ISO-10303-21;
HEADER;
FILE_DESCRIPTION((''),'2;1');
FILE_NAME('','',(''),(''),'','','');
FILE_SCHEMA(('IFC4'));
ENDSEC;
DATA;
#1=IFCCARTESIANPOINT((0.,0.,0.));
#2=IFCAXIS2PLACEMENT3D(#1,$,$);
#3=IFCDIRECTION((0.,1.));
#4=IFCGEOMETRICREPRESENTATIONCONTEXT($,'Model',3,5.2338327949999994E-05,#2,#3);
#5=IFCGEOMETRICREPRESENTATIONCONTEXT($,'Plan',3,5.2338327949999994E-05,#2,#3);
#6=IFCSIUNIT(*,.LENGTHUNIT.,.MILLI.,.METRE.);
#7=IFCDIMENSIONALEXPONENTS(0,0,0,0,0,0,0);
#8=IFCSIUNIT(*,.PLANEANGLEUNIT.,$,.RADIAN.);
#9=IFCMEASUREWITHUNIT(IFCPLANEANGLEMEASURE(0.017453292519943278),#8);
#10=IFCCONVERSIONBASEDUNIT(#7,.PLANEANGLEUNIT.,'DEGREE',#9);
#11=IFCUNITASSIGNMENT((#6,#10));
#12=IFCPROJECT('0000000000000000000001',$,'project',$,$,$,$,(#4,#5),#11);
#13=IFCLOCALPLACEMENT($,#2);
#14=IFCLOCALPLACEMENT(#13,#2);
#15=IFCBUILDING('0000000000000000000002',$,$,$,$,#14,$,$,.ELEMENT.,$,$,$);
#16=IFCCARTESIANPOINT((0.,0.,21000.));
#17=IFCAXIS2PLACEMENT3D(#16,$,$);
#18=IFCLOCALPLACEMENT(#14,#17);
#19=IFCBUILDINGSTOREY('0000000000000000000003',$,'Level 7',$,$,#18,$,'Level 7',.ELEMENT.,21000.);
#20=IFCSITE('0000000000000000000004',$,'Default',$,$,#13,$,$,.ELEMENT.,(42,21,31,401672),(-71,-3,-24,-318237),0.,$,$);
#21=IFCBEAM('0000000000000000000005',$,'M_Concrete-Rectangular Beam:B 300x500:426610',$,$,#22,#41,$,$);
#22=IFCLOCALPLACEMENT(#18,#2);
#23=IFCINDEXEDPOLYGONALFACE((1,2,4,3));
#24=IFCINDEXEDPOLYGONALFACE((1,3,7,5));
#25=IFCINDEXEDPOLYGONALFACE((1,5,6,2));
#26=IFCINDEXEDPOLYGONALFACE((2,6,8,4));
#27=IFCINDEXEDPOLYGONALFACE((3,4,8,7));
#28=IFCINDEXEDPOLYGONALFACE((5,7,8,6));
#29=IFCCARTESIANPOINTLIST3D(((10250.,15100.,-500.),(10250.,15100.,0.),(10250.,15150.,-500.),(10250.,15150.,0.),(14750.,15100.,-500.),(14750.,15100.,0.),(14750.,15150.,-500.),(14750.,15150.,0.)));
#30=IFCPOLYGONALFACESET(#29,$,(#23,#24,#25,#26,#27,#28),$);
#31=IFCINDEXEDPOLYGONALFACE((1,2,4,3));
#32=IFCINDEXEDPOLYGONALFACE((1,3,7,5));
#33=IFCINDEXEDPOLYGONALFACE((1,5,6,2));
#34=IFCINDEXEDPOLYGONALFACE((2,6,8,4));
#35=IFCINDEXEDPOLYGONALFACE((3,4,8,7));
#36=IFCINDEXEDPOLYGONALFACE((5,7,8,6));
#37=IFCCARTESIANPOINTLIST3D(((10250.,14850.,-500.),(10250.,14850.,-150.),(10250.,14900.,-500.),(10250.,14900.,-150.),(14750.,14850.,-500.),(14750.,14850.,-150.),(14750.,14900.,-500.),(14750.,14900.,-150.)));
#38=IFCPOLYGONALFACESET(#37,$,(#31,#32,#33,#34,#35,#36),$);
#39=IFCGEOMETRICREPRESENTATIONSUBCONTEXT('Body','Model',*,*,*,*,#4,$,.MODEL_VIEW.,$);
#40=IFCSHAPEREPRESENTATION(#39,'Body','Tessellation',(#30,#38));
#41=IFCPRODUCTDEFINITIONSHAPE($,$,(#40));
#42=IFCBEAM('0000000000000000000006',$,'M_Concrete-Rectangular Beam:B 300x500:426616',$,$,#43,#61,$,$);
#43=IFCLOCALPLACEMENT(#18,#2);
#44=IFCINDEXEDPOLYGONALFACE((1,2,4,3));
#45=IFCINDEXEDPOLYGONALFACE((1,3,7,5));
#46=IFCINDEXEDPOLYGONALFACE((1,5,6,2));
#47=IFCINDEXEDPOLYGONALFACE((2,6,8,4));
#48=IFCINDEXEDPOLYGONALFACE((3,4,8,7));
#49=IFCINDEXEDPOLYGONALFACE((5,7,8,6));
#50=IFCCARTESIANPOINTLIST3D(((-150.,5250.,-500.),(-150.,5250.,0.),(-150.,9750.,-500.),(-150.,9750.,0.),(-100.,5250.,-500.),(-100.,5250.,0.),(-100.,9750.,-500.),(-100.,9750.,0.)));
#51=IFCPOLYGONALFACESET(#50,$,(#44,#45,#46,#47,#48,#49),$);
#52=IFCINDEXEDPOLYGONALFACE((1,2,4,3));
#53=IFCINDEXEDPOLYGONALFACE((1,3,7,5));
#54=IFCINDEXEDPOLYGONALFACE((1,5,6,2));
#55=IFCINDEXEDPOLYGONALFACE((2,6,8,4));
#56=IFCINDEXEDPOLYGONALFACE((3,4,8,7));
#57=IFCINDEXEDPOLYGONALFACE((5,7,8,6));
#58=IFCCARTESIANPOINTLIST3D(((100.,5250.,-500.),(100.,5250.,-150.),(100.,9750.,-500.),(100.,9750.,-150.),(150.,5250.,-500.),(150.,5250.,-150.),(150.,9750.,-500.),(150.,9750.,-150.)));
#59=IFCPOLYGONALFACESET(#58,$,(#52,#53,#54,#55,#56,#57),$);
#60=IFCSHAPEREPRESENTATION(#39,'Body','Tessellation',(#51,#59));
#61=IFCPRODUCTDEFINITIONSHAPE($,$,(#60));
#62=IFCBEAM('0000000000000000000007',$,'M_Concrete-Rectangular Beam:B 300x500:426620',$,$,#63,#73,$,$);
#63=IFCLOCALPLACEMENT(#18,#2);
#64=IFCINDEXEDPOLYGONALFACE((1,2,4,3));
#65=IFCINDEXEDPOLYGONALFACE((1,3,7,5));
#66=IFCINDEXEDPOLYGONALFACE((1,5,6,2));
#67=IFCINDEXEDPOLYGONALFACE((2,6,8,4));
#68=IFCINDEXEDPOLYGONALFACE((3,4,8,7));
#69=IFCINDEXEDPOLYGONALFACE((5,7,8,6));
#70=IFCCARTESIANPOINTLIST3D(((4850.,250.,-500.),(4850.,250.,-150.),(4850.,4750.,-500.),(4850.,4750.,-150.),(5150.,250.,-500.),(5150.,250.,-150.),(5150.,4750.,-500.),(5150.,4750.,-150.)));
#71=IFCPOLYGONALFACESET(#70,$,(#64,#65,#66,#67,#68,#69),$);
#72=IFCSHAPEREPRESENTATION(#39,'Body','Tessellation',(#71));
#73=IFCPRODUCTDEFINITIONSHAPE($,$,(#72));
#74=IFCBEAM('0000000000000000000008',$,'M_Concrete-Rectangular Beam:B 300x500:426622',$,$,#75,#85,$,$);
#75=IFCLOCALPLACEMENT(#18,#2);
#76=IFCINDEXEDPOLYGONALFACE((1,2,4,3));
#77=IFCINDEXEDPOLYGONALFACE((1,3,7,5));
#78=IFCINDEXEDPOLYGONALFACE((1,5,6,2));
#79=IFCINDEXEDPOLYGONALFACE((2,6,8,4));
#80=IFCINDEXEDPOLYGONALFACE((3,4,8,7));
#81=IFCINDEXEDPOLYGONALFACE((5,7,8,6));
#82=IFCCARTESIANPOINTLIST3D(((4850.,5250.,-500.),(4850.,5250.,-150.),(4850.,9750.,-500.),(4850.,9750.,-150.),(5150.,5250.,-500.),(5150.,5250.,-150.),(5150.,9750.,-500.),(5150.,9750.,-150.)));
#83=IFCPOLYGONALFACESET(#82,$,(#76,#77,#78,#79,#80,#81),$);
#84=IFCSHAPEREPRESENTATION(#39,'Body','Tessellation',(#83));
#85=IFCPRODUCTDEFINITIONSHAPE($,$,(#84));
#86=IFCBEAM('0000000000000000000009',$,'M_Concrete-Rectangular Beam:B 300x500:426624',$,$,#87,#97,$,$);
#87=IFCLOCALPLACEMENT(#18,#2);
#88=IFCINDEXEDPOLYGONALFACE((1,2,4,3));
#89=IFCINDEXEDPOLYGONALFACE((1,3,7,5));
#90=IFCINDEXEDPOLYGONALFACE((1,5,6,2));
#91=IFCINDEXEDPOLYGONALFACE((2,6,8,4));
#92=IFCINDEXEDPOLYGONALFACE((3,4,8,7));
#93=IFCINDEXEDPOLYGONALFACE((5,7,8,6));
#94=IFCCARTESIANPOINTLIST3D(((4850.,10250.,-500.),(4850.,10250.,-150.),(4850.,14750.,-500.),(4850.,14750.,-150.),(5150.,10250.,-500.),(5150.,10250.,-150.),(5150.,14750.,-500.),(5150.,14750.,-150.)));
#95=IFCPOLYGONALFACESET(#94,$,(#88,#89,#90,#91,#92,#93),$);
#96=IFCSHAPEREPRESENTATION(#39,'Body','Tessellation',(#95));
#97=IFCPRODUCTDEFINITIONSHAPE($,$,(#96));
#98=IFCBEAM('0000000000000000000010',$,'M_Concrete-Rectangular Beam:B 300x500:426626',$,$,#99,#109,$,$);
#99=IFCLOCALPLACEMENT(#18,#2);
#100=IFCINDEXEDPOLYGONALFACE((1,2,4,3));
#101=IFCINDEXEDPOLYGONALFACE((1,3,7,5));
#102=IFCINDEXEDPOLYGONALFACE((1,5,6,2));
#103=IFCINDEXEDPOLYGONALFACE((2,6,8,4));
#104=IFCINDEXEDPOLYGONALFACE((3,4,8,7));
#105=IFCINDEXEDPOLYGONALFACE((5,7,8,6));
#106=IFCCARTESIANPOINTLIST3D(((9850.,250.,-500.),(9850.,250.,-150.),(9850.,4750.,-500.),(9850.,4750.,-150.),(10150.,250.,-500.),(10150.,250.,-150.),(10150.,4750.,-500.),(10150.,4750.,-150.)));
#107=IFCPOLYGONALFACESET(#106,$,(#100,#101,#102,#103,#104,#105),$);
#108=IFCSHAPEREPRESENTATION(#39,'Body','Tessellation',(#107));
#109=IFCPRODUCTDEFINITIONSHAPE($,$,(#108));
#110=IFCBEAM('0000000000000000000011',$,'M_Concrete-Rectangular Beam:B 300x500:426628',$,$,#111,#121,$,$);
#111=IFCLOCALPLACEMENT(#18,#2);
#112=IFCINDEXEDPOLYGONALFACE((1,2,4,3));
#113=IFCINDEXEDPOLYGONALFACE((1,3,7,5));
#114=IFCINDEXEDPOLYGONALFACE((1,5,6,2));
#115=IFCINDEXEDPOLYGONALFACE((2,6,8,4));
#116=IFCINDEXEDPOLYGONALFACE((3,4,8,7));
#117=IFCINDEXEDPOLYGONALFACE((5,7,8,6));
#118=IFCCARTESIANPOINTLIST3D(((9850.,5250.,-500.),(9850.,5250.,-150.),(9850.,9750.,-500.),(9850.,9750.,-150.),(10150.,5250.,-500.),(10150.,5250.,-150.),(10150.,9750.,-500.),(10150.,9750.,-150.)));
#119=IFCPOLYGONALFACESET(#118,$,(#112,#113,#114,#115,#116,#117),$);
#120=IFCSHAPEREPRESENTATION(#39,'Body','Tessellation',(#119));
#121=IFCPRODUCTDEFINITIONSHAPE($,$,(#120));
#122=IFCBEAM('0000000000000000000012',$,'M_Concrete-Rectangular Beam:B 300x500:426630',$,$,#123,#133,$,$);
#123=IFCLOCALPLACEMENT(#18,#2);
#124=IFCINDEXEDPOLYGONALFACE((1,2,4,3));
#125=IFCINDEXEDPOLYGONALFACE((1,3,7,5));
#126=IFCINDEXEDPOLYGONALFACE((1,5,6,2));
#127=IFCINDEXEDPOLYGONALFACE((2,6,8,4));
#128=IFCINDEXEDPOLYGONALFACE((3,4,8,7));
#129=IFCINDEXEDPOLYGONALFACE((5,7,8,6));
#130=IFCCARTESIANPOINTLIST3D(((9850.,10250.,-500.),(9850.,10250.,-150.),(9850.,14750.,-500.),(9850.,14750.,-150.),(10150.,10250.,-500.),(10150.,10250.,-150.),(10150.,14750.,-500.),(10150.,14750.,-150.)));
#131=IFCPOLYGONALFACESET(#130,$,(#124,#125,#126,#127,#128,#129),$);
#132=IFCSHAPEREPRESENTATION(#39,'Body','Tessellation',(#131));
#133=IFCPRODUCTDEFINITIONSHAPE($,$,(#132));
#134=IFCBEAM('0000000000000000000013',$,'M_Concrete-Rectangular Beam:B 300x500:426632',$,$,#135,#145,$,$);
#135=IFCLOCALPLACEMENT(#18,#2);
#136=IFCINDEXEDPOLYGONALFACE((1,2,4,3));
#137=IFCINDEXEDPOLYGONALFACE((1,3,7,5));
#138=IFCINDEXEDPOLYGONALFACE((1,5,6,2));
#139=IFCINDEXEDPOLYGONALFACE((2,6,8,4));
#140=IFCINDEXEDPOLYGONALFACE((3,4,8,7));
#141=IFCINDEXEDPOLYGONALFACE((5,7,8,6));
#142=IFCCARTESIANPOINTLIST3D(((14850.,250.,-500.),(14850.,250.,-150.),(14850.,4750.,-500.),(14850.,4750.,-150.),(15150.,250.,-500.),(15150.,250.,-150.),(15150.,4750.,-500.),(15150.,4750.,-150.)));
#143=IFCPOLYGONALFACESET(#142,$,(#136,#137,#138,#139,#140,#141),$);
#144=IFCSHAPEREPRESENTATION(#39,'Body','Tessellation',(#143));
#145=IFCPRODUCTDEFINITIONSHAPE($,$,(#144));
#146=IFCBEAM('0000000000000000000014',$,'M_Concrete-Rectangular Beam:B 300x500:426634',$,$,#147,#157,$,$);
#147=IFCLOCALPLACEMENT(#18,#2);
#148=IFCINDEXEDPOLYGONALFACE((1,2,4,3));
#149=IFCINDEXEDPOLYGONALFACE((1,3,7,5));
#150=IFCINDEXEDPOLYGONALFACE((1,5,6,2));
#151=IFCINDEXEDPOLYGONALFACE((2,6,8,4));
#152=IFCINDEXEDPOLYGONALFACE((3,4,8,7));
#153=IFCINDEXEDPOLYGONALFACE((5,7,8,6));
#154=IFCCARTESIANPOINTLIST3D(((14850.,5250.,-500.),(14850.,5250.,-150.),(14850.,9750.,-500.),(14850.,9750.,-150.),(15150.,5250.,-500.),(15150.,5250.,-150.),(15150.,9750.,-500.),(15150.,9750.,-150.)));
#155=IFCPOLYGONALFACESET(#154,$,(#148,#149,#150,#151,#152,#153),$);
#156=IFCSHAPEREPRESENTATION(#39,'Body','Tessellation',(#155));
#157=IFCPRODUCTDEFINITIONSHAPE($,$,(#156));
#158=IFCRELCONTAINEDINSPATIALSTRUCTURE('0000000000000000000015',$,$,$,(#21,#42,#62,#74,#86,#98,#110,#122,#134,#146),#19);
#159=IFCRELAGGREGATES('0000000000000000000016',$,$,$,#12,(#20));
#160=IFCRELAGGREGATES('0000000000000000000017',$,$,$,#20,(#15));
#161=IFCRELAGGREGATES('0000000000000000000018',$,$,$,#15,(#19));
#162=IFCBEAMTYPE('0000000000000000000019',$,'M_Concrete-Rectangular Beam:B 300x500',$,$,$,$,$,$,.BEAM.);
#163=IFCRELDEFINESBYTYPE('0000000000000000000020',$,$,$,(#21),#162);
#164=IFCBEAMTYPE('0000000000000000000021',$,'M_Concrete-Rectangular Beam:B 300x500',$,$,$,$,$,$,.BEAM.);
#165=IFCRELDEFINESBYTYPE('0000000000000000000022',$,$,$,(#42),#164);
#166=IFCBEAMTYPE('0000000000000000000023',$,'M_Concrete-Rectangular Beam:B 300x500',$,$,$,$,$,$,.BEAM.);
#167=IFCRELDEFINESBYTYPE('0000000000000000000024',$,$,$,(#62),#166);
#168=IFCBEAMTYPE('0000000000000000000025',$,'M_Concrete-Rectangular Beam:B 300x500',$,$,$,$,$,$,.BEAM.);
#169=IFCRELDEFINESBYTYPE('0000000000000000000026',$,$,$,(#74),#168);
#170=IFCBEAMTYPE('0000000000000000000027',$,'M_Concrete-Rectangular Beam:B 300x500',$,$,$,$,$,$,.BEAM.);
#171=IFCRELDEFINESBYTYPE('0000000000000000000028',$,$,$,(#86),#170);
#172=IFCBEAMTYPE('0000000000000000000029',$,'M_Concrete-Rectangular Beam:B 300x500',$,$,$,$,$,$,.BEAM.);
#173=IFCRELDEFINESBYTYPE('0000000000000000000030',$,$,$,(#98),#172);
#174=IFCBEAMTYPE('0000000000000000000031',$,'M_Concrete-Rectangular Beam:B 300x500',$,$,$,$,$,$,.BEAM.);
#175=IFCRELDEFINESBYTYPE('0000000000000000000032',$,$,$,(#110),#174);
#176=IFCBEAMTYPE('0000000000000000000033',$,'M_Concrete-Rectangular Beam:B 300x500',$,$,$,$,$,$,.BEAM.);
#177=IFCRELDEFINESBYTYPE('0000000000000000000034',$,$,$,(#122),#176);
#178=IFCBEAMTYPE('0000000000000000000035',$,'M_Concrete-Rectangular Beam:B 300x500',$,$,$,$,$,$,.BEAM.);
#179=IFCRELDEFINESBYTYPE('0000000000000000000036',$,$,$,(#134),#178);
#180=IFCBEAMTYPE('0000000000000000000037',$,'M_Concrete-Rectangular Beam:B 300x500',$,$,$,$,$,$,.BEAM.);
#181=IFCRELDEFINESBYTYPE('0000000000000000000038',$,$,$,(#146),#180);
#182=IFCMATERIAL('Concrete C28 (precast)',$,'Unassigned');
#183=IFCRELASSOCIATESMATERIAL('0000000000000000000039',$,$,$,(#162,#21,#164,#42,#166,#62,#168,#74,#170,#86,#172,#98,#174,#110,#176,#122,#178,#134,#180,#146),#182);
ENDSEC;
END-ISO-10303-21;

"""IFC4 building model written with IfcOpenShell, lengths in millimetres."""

from ifc_helpers import new_model, entity, si_unit, converted_unit, direction, frame, origin, place, context, subcontext, project, spatial, indexed_curve, outline, extrude, source, transform, mapped, material, type_object, type_shapes, element, save


model = new_model("IFC4")

# Units and contexts
model_context = context("Model", 3, precision=5.2338327949999994e-05, world=origin(), true_north=direction((0.0, 1.0)))
plan_context = context("Plan", 3, precision=5.2338327949999994e-05, world=origin(), true_north=direction((0.0, 1.0)))
body_context = subcontext(model_context, "Body", "Model", "MODEL_VIEW")
ifc_project = project(units=[si_unit("LENGTHUNIT", "METRE", prefix="MILLI"), converted_unit("PLANEANGLEUNIT", "DEGREE", entity("IfcPlaneAngleMeasure", 0.017453292519943278), si_unit("PLANEANGLEUNIT", "RADIAN"), dimensions=[0, 0, 0, 0, 0, 0, 0])], contexts=[model_context, plan_context])

# Site, building, storey
site_placement = place(None, origin())
site = spatial("IfcSite", under=ifc_project, at=site_placement, Name="Default", CompositionType="ELEMENT", RefLatitude=(42, 21, 31, 401672), RefLongitude=(-71, -3, -24, -318237), RefElevation=0.0)
building_placement = place(site_placement, origin())
building = spatial("IfcBuilding", under=site, at=building_placement, CompositionType="ELEMENT")
storey_placement = place(building_placement, frame((0.0, 0.0, 21000.0)))
storey = spatial("IfcBuildingStorey", under=building, at=storey_placement, Name="Level 7", LongName="Level 7", CompositionType="ELEMENT", Elevation=21000.0)

# Beams
ifc_material = material(Name="Concrete C28 (precast)", Category="Unassigned")
beam_type_1 = type_object("IfcBeamType", Name="M_Concrete-Rectangular Beam:B 300x500", PredefinedType="BEAM", material=ifc_material)
shared_shape_1 = source(origin(), body_context, "Body", "SweptSolid", [
    extrude(outline(indexed_curve([(-250.0, -25.0), (250.0, -25.0), (250.0, 25.0), (-250.0, 25.0), (-250.0, -25.0)], self_intersect=False)), frame((10250.0, 15125.0, 20750.0), z_axis=(1.0, 0.0, 0.0), x_axis=(0.0, 0.0, -1.0)), (0.0, 0.0, 1.0), 4500.0),
    extrude(outline(indexed_curve([(-175.0, -25.0), (175.0, -25.0), (175.0, 25.0), (-175.0, 25.0), (-175.0, -25.0)], self_intersect=False)), frame((10250.0, 14875.0, 20675.0), z_axis=(1.0, 0.0, 0.0), x_axis=(0.0, 0.0, -1.0)), (0.0, 0.0, 1.0), 4500.0),
])
type_shapes(beam_type_1, [shared_shape_1])
beam_1_placement = place(storey_placement, frame((0.0, 0.0, -21000.0)))
element("IfcBeam", 1, at=beam_1_placement, inside=storey, type_object=beam_type_1, material=ifc_material, Name="M_Concrete-Rectangular Beam:B 300x500:426610", context=body_context, shape_type="MappedRepresentation", body=[
    mapped(shared_shape_1, transform((0.0, 0.0, 0.0), scale=1.0)),
])
beam_type_2 = type_object("IfcBeamType", Name="M_Concrete-Rectangular Beam:B 300x500", PredefinedType="BEAM", material=ifc_material)
shared_shape_2 = source(origin(), body_context, "Body", "SweptSolid", [
    extrude(outline(indexed_curve([(-25.0, -250.0), (25.0, -250.0), (25.0, 250.0), (-25.0, 250.0), (-25.0, -250.0)], self_intersect=False)), frame((-125.0, 5250.0, 20750.0), z_axis=(0.0, 1.0, 0.0), x_axis=(-1.0, 0.0, 0.0)), (0.0, 0.0, 1.0), 4500.0),
    extrude(outline(indexed_curve([(-25.0, -175.0), (25.0, -175.0), (25.0, 175.0), (-25.0, 175.0), (-25.0, -175.0)], self_intersect=False)), frame((125.0, 5250.0, 20675.0), z_axis=(0.0, 1.0, 0.0), x_axis=(-1.0, 0.0, 0.0)), (0.0, 0.0, 1.0), 4500.0),
])
type_shapes(beam_type_2, [shared_shape_2])
beam_2_placement = place(storey_placement, frame((0.0, 0.0, -21000.0)))
element("IfcBeam", 2, at=beam_2_placement, inside=storey, type_object=beam_type_2, material=ifc_material, Name="M_Concrete-Rectangular Beam:B 300x500:426616", context=body_context, shape_type="MappedRepresentation", body=[
    mapped(shared_shape_2, transform((0.0, 0.0, 0.0), scale=1.0)),
])
beam_type_3 = type_object("IfcBeamType", Name="M_Concrete-Rectangular Beam:B 300x500", PredefinedType="BEAM", material=ifc_material)
shared_shape_3 = source(origin(), body_context, "Body", "SweptSolid", [
    extrude(outline(indexed_curve([(-150.0, -175.0), (150.0, -175.0), (150.0, 175.0), (-150.0, 175.0), (-150.0, -175.0)], self_intersect=False)), frame((5000.0, 250.0, 20675.0), z_axis=(0.0, 1.0, 0.0), x_axis=(-1.0, 0.0, 0.0)), (0.0, 0.0, 1.0), 4500.0),
])
type_shapes(beam_type_3, [shared_shape_3])
beam_3_placement = place(storey_placement, frame((0.0, 0.0, -21000.0)))
element("IfcBeam", 3, at=beam_3_placement, inside=storey, type_object=beam_type_3, material=ifc_material, Name="M_Concrete-Rectangular Beam:B 300x500:426620", context=body_context, shape_type="MappedRepresentation", body=[
    mapped(shared_shape_3, transform((0.0, 0.0, 0.0), scale=1.0)),
])
beam_type_4 = type_object("IfcBeamType", Name="M_Concrete-Rectangular Beam:B 300x500", PredefinedType="BEAM", material=ifc_material)
shared_shape_4 = source(origin(), body_context, "Body", "SweptSolid", [
    extrude(outline(indexed_curve([(-150.0, -175.0), (150.0, -175.0), (150.0, 175.0), (-150.0, 175.0), (-150.0, -175.0)], self_intersect=False)), frame((5000.0, 5250.0, 20675.0), z_axis=(0.0, 1.0, 0.0), x_axis=(-1.0, 0.0, 0.0)), (0.0, 0.0, 1.0), 4500.0),
])
type_shapes(beam_type_4, [shared_shape_4])
beam_4_placement = place(storey_placement, frame((0.0, 0.0, -21000.0)))
element("IfcBeam", 4, at=beam_4_placement, inside=storey, type_object=beam_type_4, material=ifc_material, Name="M_Concrete-Rectangular Beam:B 300x500:426622", context=body_context, shape_type="MappedRepresentation", body=[
    mapped(shared_shape_4, transform((0.0, 0.0, 0.0), scale=1.0)),
])
beam_type_5 = type_object("IfcBeamType", Name="M_Concrete-Rectangular Beam:B 300x500", PredefinedType="BEAM", material=ifc_material)
shared_shape_5 = source(origin(), body_context, "Body", "SweptSolid", [
    extrude(outline(indexed_curve([(-150.0, -175.0), (150.0, -175.0), (150.0, 175.0), (-150.0, 175.0), (-150.0, -175.0)], self_intersect=False)), frame((5000.0, 10250.0, 20675.0), z_axis=(0.0, 1.0, 0.0), x_axis=(-1.0, 0.0, 0.0)), (0.0, 0.0, 1.0), 4500.0),
])
type_shapes(beam_type_5, [shared_shape_5])
beam_5_placement = place(storey_placement, frame((0.0, 0.0, -21000.0)))
element("IfcBeam", 5, at=beam_5_placement, inside=storey, type_object=beam_type_5, material=ifc_material, Name="M_Concrete-Rectangular Beam:B 300x500:426624", context=body_context, shape_type="MappedRepresentation", body=[
    mapped(shared_shape_5, transform((0.0, 0.0, 0.0), scale=1.0)),
])
beam_type_6 = type_object("IfcBeamType", Name="M_Concrete-Rectangular Beam:B 300x500", PredefinedType="BEAM", material=ifc_material)
shared_shape_6 = source(origin(), body_context, "Body", "SweptSolid", [
    extrude(outline(indexed_curve([(-150.0, -175.0), (150.0, -175.0), (150.0, 175.0), (-150.0, 175.0), (-150.0, -175.0)], self_intersect=False)), frame((10000.0, 250.0, 20675.0), z_axis=(0.0, 1.0, 0.0), x_axis=(-1.0, 0.0, 0.0)), (0.0, 0.0, 1.0), 4500.0),
])
type_shapes(beam_type_6, [shared_shape_6])
beam_6_placement = place(storey_placement, frame((0.0, 0.0, -21000.0)))
element("IfcBeam", 6, at=beam_6_placement, inside=storey, type_object=beam_type_6, material=ifc_material, Name="M_Concrete-Rectangular Beam:B 300x500:426626", context=body_context, shape_type="MappedRepresentation", body=[
    mapped(shared_shape_6, transform((0.0, 0.0, 0.0), scale=1.0)),
])
beam_type_7 = type_object("IfcBeamType", Name="M_Concrete-Rectangular Beam:B 300x500", PredefinedType="BEAM", material=ifc_material)
shared_shape_7 = source(origin(), body_context, "Body", "SweptSolid", [
    extrude(outline(indexed_curve([(-150.0, -175.0), (150.0, -175.0), (150.0, 175.0), (-150.0, 175.0), (-150.0, -175.0)], self_intersect=False)), frame((10000.0, 5250.0, 20675.0), z_axis=(0.0, 1.0, 0.0), x_axis=(-1.0, 0.0, 0.0)), (0.0, 0.0, 1.0), 4500.0),
])
type_shapes(beam_type_7, [shared_shape_7])
beam_7_placement = place(storey_placement, frame((0.0, 0.0, -21000.0)))
element("IfcBeam", 7, at=beam_7_placement, inside=storey, type_object=beam_type_7, material=ifc_material, Name="M_Concrete-Rectangular Beam:B 300x500:426628", context=body_context, shape_type="MappedRepresentation", body=[
    mapped(shared_shape_7, transform((0.0, 0.0, 0.0), scale=1.0)),
])
beam_type_8 = type_object("IfcBeamType", Name="M_Concrete-Rectangular Beam:B 300x500", PredefinedType="BEAM", material=ifc_material)
shared_shape_8 = source(origin(), body_context, "Body", "SweptSolid", [
    extrude(outline(indexed_curve([(-150.0, -175.0), (150.0, -175.0), (150.0, 175.0), (-150.0, 175.0), (-150.0, -175.0)], self_intersect=False)), frame((10000.0, 10250.0, 20675.0), z_axis=(0.0, 1.0, 0.0), x_axis=(-1.0, 0.0, 0.0)), (0.0, 0.0, 1.0), 4500.0),
])
type_shapes(beam_type_8, [shared_shape_8])
beam_8_placement = place(storey_placement, frame((0.0, 0.0, -21000.0)))
element("IfcBeam", 8, at=beam_8_placement, inside=storey, type_object=beam_type_8, material=ifc_material, Name="M_Concrete-Rectangular Beam:B 300x500:426630", context=body_context, shape_type="MappedRepresentation", body=[
    mapped(shared_shape_8, transform((0.0, 0.0, 0.0), scale=1.0)),
])
beam_type_9 = type_object("IfcBeamType", Name="M_Concrete-Rectangular Beam:B 300x500", PredefinedType="BEAM", material=ifc_material)
shared_shape_9 = source(origin(), body_context, "Body", "SweptSolid", [
    extrude(outline(indexed_curve([(-150.0, -175.0), (150.0, -175.0), (150.0, 175.0), (-150.0, 175.0), (-150.0, -175.0)], self_intersect=False)), frame((15000.0, 250.0, 20675.0), z_axis=(0.0, 1.0, 0.0), x_axis=(-1.0, 0.0, 0.0)), (0.0, 0.0, 1.0), 4500.0),
])
type_shapes(beam_type_9, [shared_shape_9])
beam_9_placement = place(storey_placement, frame((0.0, 0.0, -21000.0)))
element("IfcBeam", 9, at=beam_9_placement, inside=storey, type_object=beam_type_9, material=ifc_material, Name="M_Concrete-Rectangular Beam:B 300x500:426632", context=body_context, shape_type="MappedRepresentation", body=[
    mapped(shared_shape_9, transform((0.0, 0.0, 0.0), scale=1.0)),
])
beam_type_10 = type_object("IfcBeamType", Name="M_Concrete-Rectangular Beam:B 300x500", PredefinedType="BEAM", material=ifc_material)
shared_shape_10 = source(origin(), body_context, "Body", "SweptSolid", [
    extrude(outline(indexed_curve([(-150.0, -175.0), (150.0, -175.0), (150.0, 175.0), (-150.0, 175.0), (-150.0, -175.0)], self_intersect=False)), frame((15000.0, 5250.0, 20675.0), z_axis=(0.0, 1.0, 0.0), x_axis=(-1.0, 0.0, 0.0)), (0.0, 0.0, 1.0), 4500.0),
])
type_shapes(beam_type_10, [shared_shape_10])
beam_10_placement = place(storey_placement, frame((0.0, 0.0, -21000.0)))
element("IfcBeam", 10, at=beam_10_placement, inside=storey, type_object=beam_type_10, material=ifc_material, Name="M_Concrete-Rectangular Beam:B 300x500:426634", context=body_context, shape_type="MappedRepresentation", body=[
    mapped(shared_shape_10, transform((0.0, 0.0, 0.0), scale=1.0)),
])

save(model, "model.ifc")
